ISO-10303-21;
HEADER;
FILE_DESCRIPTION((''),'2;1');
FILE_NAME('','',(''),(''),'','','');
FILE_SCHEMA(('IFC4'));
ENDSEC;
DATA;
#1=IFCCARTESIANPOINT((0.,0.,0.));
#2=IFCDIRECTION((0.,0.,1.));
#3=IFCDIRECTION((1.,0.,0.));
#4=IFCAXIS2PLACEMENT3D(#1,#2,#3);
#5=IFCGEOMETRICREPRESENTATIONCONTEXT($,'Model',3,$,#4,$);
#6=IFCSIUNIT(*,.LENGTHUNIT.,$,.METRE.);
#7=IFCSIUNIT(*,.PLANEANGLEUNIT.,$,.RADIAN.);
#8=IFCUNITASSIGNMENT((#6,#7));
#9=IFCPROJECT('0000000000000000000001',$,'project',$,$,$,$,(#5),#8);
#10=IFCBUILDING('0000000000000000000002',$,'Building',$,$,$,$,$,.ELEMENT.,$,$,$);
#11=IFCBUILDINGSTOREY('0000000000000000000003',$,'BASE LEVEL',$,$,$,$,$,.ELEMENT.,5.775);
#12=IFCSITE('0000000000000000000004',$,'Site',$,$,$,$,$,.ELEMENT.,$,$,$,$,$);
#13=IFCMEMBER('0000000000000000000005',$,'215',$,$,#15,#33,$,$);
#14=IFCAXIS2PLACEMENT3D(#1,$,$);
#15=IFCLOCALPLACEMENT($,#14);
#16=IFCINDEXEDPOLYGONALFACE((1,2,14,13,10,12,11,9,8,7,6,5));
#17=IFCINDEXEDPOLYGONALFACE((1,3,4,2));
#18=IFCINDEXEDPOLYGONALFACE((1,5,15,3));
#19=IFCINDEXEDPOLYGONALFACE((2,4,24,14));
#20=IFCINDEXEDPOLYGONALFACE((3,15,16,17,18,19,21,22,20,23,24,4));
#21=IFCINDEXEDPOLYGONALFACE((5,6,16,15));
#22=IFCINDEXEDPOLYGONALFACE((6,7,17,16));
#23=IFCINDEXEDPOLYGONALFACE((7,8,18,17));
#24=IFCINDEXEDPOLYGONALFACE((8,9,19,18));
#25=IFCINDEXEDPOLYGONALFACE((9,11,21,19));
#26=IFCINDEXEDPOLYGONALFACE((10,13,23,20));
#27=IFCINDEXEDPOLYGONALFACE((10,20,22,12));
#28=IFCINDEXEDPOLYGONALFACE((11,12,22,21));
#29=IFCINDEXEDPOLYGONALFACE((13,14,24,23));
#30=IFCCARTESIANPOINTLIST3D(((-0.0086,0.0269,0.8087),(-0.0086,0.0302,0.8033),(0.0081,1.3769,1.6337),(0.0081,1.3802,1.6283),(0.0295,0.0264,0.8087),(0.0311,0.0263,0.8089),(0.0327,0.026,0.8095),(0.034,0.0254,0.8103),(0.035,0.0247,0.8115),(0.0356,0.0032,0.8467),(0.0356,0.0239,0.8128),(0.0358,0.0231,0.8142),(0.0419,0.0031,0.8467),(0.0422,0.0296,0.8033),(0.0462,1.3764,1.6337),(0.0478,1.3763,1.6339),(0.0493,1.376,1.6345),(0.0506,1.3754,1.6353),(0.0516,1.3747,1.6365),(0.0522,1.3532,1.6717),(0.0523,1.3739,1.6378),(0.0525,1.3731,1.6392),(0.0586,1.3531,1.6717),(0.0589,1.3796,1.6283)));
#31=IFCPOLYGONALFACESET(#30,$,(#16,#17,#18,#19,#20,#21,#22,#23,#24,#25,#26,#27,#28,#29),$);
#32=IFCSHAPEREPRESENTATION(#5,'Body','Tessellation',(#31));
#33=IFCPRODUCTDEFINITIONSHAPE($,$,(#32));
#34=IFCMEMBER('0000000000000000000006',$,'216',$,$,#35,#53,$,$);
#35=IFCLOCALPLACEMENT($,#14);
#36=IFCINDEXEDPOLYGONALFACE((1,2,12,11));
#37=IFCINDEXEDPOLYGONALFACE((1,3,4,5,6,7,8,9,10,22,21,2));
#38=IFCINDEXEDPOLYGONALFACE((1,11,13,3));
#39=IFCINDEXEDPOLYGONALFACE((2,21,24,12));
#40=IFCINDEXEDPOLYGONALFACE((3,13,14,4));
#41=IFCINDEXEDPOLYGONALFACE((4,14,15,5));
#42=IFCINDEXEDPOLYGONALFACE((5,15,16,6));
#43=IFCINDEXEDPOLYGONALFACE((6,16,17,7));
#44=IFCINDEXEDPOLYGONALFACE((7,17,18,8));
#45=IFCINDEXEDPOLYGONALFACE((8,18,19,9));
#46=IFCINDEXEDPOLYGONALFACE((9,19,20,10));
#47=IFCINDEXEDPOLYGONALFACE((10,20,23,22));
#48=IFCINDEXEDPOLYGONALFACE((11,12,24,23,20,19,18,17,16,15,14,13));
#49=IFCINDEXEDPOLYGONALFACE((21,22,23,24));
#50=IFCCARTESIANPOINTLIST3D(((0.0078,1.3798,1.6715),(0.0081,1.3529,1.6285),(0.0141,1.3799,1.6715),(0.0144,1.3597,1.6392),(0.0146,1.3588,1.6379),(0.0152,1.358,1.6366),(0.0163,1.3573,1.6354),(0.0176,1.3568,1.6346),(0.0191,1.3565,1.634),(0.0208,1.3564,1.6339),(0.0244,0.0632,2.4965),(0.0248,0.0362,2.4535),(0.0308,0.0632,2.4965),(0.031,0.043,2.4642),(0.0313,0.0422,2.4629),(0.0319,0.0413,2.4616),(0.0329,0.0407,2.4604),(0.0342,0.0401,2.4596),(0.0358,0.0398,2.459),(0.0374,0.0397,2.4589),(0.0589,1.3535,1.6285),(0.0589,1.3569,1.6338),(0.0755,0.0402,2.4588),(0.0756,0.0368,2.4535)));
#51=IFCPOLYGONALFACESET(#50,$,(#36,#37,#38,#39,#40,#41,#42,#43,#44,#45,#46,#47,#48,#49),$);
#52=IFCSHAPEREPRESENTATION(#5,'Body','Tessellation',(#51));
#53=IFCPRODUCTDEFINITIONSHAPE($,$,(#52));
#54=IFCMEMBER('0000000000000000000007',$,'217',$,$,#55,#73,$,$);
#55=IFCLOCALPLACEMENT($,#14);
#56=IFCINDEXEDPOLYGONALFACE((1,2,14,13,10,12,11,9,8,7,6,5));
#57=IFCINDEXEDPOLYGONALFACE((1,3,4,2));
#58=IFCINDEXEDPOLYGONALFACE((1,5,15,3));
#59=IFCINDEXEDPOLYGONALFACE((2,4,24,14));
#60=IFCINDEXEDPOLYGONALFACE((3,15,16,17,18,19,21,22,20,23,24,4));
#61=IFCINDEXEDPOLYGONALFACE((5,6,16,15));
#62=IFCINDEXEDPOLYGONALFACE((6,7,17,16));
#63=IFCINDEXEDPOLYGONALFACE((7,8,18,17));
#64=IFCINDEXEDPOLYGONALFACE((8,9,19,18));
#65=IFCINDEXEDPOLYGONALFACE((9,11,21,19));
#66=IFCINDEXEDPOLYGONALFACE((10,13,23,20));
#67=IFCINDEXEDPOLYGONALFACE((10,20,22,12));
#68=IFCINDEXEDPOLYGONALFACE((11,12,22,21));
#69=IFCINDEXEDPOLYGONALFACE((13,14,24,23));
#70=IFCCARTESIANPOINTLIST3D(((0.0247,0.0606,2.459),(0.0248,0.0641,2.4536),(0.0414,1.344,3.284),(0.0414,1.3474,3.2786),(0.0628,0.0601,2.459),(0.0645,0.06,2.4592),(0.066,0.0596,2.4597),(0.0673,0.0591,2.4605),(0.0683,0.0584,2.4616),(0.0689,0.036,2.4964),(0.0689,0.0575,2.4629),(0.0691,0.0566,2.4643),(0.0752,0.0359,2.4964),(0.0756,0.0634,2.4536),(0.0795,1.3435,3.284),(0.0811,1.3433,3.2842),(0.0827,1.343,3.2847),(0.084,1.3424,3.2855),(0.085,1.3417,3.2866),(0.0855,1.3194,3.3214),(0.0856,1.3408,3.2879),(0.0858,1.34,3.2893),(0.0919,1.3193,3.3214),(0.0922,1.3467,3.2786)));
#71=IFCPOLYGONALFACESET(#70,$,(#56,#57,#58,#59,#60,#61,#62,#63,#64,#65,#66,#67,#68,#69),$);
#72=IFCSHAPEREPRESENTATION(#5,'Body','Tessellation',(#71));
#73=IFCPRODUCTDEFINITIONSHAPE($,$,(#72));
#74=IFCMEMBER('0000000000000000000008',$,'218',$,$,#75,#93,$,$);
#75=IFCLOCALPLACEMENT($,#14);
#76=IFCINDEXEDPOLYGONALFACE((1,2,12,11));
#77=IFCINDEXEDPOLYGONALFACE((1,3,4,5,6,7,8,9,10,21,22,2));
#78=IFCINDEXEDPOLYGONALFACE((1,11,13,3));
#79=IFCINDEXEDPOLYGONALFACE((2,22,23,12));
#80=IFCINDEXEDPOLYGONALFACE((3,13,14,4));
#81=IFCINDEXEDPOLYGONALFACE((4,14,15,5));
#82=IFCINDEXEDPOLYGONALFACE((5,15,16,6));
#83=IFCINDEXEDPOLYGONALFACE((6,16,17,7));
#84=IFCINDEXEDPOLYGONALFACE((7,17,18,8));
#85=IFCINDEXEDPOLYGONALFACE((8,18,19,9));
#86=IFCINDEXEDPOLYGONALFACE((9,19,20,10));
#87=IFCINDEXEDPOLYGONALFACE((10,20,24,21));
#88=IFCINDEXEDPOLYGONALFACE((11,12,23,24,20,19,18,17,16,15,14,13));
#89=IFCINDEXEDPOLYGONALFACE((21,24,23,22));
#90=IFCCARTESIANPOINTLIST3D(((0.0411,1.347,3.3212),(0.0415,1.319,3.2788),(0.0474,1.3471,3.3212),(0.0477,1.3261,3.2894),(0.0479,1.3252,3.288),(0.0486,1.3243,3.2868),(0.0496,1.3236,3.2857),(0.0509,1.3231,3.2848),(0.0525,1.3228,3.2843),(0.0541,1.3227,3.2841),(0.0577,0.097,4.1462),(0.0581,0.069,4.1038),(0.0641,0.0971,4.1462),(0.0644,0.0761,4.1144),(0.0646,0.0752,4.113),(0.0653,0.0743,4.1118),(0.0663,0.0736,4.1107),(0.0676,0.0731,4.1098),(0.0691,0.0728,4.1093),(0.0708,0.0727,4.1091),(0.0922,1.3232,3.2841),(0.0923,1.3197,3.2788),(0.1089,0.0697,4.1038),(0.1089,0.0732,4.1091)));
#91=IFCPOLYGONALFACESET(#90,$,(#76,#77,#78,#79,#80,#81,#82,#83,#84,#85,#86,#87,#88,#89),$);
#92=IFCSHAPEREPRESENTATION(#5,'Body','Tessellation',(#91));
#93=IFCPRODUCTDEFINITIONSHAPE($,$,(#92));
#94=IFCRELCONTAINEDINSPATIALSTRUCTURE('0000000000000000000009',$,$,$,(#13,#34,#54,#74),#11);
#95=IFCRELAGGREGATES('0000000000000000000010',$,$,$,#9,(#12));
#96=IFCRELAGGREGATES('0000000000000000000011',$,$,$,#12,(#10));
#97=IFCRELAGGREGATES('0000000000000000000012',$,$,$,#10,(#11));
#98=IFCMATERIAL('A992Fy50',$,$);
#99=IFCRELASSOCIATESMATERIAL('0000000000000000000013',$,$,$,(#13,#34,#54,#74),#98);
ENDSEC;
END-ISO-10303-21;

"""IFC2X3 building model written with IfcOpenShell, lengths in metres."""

from ifc_helpers import new_model, si_unit, frame, origin_with_axes, origin_2d_with_axis, place, context, project, spatial, l_section, extrude, material, element, save


model = new_model("IFC2X3")

# Units and contexts
model_context = context("Model", 3, world=origin_with_axes())
ifc_project = project(units=[si_unit("LENGTHUNIT", "METRE"), si_unit("PLANEANGLEUNIT", "RADIAN")], contexts=[model_context])

# Site, building, storey
site = spatial("IfcSite", under=ifc_project, Name="Site", CompositionType="ELEMENT")
building = spatial("IfcBuilding", under=site, Name="Building", CompositionType="ELEMENT")
storey = spatial("IfcBuildingStorey", under=building, Name="BASE LEVEL", CompositionType="ELEMENT", Elevation=5.775)

# Members
ifc_material = material(Name="A992Fy50")
member_1_placement = place(None, frame((0.0167, 0.0167, 0.825), z_axis=(0.010534, 0.853234, 0.521421), x_axis=(-0.999924, 0.012345, 0.0)))
element("IfcMember", 1, at=member_1_placement, inside=storey, material=ifc_material, Name="215", context=model_context, shape_type="SweptSolid", body=[
    extrude(l_section(Depth=0.0508, Width=0.0508, Thickness=0.0063, FilletRadius=0.0063, at=origin_2d_with_axis()), origin_with_axes(), (0.0, 0.0, 1.0), 1.5822),
])
member_2_placement = place(None, frame((0.0333, 1.3667, 1.65), z_axis=(0.010726, -0.847346, 0.530932), x_axis=(0.999927, 0.012047, 0.0)))
element("IfcMember", 2, at=member_2_placement, inside=storey, material=ifc_material, Name="216", context=model_context, shape_type="SweptSolid", body=[
    extrude(l_section(Depth=0.0508, Width=0.0508, Thickness=0.0063, FilletRadius=0.0063, at=origin_2d_with_axis()), origin_with_axes(), (0.0, 0.0, 1.0), 1.5539),
])
member_3_placement = place(None, frame((0.05, 0.05, 2.475), z_axis=(0.010924, 0.841128, 0.540725), x_axis=(-0.999924, 0.012345, 0.0)))
element("IfcMember", 3, at=member_3_placement, inside=storey, material=ifc_material, Name="217", context=model_context, shape_type="SweptSolid", body=[
    extrude(l_section(Depth=0.0508, Width=0.0508, Thickness=0.0063, FilletRadius=0.0063, at=origin_2d_with_axis()), origin_with_axes(), (0.0, 0.0, 1.0), 1.5257),
])
member_4_placement = place(None, frame((0.0667, 1.3333, 3.3), z_axis=(0.011127, -0.834558, 0.550808), x_axis=(0.999911, 0.013332, 0.0)))
element("IfcMember", 4, at=member_4_placement, inside=storey, material=ifc_material, Name="218", context=model_context, shape_type="SweptSolid", body=[
    extrude(l_section(Depth=0.0508, Width=0.0508, Thickness=0.0063, FilletRadius=0.0063, at=origin_2d_with_axis()), origin_with_axes(), (0.0, 0.0, 1.0), 1.4978),
])

save(model, "model.ifc")
